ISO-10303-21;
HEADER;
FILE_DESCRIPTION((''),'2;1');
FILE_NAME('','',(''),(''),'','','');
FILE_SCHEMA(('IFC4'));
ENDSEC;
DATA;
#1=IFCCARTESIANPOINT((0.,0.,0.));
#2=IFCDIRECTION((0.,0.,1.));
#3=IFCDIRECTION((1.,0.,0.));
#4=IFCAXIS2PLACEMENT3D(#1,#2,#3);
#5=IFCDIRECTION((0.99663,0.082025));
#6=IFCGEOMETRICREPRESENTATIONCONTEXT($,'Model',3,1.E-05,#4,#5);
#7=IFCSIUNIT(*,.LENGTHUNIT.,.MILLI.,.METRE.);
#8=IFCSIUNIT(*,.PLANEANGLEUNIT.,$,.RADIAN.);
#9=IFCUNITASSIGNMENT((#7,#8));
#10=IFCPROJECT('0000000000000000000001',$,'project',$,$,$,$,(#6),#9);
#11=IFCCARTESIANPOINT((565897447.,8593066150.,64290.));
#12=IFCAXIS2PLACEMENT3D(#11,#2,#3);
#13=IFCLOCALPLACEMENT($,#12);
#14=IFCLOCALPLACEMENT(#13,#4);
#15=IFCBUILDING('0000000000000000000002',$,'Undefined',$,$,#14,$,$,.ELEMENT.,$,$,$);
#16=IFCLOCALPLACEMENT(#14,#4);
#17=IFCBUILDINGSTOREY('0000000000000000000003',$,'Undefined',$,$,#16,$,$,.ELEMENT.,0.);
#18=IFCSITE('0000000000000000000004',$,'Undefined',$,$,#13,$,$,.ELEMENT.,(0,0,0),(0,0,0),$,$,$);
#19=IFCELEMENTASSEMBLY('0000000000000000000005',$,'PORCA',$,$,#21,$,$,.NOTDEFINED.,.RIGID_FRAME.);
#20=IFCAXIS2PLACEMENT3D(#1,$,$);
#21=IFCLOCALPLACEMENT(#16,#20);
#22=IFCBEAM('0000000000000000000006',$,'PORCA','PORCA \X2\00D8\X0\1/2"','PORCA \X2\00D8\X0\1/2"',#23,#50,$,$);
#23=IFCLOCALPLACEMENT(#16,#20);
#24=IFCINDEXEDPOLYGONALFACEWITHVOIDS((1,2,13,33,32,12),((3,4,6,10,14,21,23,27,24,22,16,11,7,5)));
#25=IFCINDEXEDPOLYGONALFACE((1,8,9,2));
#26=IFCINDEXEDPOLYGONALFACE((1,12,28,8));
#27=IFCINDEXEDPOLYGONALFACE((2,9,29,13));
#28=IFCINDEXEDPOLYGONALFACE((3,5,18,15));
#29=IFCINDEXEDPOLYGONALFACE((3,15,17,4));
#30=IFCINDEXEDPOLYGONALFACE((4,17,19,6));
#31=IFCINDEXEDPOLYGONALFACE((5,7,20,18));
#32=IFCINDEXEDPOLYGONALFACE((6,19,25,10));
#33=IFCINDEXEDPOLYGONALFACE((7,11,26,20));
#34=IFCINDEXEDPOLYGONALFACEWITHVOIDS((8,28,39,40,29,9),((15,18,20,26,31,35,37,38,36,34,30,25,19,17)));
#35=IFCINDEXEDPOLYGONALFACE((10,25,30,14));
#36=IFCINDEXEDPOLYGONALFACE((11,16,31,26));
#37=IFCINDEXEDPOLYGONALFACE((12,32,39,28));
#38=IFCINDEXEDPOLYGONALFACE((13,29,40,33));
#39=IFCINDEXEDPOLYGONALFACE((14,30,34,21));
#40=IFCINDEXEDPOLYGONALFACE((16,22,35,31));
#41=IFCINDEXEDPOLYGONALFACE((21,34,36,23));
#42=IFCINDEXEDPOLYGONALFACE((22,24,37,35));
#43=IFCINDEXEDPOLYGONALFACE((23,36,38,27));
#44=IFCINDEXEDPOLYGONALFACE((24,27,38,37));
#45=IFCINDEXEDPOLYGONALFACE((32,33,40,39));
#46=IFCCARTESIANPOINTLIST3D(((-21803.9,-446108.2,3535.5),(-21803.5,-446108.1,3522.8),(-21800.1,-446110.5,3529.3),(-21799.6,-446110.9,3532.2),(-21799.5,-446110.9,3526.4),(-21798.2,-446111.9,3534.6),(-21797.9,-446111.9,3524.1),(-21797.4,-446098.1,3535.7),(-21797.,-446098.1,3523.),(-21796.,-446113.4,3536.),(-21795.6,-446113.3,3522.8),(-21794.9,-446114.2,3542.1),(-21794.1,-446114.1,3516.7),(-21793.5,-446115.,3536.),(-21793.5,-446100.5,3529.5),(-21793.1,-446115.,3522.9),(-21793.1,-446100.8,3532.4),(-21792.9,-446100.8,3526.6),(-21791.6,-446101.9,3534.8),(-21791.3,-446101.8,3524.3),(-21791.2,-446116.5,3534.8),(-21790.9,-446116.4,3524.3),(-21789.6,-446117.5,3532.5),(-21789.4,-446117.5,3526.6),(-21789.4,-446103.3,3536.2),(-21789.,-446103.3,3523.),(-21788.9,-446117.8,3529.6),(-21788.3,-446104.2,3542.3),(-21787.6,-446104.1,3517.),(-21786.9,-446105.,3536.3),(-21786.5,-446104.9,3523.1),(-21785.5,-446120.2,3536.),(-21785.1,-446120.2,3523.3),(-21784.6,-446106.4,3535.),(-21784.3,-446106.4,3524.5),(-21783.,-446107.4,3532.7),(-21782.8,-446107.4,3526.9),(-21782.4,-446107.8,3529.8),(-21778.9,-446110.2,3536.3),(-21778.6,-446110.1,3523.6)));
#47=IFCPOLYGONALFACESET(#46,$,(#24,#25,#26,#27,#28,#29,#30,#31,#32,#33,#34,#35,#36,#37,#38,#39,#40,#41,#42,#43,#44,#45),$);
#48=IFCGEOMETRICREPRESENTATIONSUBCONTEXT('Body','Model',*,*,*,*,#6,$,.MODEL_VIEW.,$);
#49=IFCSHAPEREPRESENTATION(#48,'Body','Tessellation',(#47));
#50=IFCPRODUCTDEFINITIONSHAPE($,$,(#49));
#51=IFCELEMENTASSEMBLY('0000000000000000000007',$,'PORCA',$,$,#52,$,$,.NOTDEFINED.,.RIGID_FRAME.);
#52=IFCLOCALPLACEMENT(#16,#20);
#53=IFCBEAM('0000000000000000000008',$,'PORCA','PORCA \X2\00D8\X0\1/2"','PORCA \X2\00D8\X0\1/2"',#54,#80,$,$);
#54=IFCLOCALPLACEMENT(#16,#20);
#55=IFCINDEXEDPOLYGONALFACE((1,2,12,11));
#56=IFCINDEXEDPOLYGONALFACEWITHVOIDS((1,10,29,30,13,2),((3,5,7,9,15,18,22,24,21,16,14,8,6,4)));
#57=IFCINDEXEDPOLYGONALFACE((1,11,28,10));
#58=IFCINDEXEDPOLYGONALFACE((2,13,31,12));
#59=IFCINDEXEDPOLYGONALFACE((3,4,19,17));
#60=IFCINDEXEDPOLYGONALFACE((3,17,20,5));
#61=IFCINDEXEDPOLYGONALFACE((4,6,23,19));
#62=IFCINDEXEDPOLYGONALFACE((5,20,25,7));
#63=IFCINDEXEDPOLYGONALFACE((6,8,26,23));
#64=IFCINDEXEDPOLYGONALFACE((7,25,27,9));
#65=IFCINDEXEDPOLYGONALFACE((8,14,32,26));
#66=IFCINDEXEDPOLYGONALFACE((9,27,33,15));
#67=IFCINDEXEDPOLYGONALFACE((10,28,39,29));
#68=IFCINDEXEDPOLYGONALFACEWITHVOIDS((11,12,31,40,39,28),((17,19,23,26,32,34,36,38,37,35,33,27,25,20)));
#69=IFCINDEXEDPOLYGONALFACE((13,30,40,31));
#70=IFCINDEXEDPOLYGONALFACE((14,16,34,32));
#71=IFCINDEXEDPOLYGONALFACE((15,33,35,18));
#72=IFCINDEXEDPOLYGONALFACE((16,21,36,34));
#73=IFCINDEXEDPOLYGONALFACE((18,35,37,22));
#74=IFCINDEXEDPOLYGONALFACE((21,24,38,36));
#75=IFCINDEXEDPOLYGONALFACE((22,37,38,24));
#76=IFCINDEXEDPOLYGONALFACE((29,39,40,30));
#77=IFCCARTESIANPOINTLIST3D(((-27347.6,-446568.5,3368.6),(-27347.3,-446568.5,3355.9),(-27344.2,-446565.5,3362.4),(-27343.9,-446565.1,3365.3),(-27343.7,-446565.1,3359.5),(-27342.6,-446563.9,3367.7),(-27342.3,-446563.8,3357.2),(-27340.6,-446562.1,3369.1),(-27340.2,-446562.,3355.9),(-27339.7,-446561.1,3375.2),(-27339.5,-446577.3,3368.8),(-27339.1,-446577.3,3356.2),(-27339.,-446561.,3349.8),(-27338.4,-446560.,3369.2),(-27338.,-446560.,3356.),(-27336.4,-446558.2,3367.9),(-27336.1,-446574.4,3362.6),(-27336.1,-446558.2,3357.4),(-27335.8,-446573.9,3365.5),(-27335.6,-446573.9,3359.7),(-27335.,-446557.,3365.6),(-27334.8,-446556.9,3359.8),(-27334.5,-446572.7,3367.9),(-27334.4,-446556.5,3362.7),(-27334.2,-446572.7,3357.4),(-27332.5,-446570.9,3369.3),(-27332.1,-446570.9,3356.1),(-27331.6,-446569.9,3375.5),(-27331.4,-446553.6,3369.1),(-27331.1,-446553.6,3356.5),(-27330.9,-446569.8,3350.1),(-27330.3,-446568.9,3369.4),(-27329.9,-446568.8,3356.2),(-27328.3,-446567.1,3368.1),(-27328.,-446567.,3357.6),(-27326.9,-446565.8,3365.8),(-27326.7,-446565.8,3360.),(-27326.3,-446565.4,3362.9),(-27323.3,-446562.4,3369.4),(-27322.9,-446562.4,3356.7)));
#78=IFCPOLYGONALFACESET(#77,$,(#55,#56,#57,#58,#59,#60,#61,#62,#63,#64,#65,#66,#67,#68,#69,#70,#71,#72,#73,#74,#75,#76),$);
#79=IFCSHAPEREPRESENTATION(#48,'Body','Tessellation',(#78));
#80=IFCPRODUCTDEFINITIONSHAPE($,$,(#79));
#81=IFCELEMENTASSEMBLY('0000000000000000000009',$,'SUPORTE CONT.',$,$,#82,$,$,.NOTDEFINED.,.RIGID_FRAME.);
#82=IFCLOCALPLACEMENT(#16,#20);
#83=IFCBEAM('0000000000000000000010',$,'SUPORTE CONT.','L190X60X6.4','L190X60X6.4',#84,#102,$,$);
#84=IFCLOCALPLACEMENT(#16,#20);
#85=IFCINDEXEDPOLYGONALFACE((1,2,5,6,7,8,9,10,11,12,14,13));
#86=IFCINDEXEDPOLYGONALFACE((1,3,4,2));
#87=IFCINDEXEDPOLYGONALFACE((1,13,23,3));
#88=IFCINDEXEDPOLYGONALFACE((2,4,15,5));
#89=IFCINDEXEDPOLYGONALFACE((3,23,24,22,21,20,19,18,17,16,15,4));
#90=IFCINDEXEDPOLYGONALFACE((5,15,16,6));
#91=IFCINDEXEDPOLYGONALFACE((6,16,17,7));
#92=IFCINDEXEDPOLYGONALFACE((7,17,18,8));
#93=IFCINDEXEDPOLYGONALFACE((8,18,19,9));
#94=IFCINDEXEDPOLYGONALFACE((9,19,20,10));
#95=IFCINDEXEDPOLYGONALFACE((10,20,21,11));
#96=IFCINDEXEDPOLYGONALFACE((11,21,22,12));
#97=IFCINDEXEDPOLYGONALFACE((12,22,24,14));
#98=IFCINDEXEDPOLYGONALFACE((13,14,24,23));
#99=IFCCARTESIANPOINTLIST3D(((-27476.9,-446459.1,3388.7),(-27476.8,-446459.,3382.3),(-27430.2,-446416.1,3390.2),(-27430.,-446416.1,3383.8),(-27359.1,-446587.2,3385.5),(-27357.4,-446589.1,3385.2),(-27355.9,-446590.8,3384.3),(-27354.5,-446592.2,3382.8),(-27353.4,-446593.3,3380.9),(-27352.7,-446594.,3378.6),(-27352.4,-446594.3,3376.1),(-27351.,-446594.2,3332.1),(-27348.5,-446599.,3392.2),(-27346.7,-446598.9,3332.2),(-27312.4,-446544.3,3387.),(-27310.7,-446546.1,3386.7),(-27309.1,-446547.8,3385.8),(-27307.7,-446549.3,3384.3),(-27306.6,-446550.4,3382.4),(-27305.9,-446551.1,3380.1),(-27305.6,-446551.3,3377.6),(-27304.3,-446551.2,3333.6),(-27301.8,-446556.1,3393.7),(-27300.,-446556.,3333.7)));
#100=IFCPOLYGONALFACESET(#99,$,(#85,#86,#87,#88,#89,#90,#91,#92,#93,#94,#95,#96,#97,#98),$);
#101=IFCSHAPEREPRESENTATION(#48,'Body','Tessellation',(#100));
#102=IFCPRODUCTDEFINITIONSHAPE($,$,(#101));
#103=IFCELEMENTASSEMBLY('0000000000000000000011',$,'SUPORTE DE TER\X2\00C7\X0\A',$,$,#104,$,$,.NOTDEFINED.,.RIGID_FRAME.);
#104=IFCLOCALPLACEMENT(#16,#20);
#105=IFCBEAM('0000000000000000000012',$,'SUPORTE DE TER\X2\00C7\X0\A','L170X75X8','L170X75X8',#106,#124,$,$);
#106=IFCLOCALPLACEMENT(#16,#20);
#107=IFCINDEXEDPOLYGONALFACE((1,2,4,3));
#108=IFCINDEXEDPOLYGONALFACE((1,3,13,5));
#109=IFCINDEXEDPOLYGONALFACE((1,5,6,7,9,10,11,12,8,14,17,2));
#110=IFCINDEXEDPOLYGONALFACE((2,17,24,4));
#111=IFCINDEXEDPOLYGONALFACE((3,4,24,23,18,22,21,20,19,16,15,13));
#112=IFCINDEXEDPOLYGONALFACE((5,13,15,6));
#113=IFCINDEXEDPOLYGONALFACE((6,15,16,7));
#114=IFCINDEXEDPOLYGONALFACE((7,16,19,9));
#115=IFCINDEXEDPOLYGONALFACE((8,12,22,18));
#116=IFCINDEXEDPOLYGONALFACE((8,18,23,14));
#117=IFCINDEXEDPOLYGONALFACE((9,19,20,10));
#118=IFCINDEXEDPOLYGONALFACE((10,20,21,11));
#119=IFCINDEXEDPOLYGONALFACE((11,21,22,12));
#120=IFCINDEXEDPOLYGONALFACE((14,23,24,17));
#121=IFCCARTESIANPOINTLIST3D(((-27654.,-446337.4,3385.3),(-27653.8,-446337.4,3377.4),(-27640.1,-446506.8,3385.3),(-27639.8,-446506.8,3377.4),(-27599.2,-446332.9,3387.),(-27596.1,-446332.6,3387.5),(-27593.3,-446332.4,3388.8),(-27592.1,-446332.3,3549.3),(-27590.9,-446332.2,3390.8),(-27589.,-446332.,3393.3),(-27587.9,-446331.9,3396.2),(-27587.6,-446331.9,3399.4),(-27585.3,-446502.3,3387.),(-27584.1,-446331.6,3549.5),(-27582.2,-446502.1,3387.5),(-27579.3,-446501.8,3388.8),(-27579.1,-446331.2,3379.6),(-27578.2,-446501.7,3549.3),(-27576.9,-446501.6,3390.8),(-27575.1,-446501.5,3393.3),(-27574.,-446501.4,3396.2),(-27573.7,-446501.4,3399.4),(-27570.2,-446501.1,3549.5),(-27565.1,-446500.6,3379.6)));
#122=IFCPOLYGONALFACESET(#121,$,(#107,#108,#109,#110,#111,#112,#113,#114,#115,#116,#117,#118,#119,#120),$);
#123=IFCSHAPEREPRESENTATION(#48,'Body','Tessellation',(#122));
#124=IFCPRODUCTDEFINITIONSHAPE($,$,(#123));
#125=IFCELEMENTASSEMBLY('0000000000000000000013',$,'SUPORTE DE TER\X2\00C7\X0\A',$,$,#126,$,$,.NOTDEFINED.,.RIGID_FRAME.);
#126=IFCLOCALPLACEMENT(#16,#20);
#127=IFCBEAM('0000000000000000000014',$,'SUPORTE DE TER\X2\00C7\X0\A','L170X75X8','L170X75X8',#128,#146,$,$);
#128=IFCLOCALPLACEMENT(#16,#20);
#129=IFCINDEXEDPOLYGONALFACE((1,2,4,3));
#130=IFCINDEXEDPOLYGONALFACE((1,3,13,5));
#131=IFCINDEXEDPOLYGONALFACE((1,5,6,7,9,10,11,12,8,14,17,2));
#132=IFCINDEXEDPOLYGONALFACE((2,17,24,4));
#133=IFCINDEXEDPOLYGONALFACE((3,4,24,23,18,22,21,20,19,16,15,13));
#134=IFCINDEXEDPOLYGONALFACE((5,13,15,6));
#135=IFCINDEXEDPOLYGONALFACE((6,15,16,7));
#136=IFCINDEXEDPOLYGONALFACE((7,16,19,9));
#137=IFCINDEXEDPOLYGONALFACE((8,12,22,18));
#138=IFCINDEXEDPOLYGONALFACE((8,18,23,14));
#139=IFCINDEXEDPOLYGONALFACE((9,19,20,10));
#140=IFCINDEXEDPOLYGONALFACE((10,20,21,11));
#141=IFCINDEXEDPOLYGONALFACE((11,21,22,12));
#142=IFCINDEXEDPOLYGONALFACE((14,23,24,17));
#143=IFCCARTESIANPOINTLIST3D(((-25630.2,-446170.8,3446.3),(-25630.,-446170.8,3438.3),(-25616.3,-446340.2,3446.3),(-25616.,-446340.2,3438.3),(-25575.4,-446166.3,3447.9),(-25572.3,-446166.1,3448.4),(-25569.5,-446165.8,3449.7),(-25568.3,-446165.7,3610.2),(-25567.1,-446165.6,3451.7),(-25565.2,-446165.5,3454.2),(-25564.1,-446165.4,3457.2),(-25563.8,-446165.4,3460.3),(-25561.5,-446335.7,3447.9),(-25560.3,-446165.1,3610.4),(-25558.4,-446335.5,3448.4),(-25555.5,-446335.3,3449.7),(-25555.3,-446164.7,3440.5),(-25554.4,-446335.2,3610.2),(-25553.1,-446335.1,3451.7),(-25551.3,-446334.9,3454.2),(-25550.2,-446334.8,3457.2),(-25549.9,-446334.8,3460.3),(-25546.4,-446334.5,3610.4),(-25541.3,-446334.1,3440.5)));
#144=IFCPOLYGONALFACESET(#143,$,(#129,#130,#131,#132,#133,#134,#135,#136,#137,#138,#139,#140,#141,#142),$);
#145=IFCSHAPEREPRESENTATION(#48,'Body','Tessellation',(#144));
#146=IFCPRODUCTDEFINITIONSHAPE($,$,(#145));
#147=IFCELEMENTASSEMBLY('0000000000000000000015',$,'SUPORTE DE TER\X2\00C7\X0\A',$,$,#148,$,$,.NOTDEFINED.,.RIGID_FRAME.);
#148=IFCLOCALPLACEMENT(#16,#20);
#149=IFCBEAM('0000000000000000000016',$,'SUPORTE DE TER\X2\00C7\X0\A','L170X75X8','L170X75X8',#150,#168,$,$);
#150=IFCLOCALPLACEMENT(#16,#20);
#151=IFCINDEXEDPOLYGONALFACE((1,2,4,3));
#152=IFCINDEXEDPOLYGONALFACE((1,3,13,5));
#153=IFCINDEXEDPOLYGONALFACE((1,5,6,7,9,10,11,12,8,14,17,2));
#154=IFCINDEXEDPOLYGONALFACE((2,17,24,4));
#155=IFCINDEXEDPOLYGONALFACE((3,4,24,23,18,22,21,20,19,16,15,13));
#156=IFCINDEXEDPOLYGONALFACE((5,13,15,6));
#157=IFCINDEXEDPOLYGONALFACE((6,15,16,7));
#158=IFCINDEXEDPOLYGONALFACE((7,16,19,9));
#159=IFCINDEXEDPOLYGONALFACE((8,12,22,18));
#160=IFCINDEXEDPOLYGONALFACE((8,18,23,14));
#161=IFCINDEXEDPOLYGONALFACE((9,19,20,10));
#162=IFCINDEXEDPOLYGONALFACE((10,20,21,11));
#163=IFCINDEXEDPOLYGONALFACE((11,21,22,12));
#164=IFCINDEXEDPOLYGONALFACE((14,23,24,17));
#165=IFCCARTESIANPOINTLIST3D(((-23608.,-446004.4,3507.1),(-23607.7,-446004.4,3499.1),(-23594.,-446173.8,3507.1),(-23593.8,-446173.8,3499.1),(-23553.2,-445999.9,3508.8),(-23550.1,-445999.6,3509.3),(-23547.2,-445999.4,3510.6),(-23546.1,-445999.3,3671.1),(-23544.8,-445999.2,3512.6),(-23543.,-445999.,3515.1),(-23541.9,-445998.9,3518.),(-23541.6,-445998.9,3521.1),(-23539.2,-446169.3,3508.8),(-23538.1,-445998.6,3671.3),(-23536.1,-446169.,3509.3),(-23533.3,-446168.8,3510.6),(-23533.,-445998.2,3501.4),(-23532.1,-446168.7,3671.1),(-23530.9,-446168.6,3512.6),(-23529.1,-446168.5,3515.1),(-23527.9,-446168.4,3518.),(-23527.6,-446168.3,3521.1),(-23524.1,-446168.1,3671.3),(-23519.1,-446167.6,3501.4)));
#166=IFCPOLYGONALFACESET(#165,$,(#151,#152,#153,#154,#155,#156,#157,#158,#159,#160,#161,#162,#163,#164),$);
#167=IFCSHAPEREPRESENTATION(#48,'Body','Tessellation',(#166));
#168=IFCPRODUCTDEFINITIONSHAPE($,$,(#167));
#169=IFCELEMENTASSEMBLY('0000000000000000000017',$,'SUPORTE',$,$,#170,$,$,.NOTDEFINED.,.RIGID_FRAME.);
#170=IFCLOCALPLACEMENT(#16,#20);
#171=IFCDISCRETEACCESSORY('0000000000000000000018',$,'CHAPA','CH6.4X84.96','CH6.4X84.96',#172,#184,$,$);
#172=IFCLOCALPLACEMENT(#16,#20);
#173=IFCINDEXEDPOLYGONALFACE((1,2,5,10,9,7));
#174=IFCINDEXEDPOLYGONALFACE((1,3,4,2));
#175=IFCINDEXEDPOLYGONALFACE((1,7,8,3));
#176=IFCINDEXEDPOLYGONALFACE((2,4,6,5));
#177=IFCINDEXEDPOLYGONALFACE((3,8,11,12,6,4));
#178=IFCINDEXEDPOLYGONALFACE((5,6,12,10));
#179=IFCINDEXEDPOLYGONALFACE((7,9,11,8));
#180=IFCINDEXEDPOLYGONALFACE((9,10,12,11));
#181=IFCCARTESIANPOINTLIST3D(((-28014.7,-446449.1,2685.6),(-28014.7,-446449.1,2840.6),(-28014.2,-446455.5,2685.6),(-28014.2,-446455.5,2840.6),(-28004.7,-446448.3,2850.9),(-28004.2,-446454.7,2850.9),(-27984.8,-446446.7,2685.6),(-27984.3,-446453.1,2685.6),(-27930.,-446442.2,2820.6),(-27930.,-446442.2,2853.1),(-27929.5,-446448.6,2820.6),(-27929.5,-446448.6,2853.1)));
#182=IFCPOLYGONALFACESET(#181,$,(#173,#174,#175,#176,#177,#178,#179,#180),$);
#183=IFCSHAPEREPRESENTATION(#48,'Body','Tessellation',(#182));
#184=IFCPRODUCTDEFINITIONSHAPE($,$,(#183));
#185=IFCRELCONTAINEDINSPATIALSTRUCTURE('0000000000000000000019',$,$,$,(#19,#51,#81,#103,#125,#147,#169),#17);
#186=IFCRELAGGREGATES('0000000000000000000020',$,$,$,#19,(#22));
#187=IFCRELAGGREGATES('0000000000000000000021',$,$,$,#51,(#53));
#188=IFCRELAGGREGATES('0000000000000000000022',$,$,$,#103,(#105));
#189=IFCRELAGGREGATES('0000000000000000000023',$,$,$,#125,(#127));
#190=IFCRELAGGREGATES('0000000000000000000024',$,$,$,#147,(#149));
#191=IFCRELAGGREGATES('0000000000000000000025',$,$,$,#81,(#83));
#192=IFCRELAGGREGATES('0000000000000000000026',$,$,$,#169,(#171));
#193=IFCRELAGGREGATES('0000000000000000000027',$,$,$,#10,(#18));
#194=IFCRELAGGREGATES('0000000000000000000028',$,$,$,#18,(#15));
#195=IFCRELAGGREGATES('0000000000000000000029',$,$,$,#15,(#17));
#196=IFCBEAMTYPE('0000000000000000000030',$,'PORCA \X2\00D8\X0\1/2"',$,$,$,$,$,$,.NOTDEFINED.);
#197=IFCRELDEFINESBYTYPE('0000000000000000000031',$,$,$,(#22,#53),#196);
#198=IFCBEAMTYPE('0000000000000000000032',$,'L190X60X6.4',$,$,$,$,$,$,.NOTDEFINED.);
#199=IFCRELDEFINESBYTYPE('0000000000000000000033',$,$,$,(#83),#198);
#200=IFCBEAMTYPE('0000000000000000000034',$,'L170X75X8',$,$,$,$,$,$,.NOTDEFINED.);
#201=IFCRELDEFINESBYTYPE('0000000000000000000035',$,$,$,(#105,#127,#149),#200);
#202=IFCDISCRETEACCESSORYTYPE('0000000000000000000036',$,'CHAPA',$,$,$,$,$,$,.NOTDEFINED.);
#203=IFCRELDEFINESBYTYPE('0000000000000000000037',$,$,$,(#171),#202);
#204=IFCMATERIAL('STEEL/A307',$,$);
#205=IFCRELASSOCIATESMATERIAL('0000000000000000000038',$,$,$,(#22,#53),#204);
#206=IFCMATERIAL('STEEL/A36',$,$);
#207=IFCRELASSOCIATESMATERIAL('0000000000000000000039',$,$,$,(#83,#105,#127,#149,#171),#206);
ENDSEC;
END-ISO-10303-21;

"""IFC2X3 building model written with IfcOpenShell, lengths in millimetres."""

from ifc_helpers import new_model, si_unit, direction, frame, origin_with_axes, origin_2d_with_axis, place, context, subcontext, project, spatial, polyline, l_section, outline, extrude, material, type_object, element, aggregate, save


model = new_model("IFC2X3")

# Units and contexts
model_context = context("Model", 3, precision=1e-05, world=origin_with_axes(), true_north=direction((0.99663, 0.082025)))
body_context = subcontext(model_context, "Body", "Model", "MODEL_VIEW")
ifc_project = project(units=[si_unit("LENGTHUNIT", "METRE", prefix="MILLI"), si_unit("PLANEANGLEUNIT", "RADIAN")], contexts=[model_context])

# Site, building, storey
site_placement = place(None, frame((565897447.0, 8593066150.0, 64290.0), z_axis=(0.0, 0.0, 1.0), x_axis=(1.0, 0.0, 0.0)))
site = spatial("IfcSite", under=ifc_project, at=site_placement, Name="Undefined", CompositionType="ELEMENT", RefLatitude=(0, 0, 0), RefLongitude=(0, 0, 0))
building_placement = place(site_placement, origin_with_axes())
building = spatial("IfcBuilding", under=site, at=building_placement, Name="Undefined", CompositionType="ELEMENT")
storey_placement = place(building_placement, origin_with_axes())
storey = spatial("IfcBuildingStorey", under=building, at=storey_placement, Name="Undefined", CompositionType="ELEMENT", Elevation=0.0)

# Element assemblies, beams
ifc_material_1 = material(Name="STEEL/A307")
assembly_1_placement = place(storey_placement, origin_with_axes())
assembly_1 = element("IfcElementAssembly", 1, at=assembly_1_placement, inside=storey, Name="PORCA", AssemblyPlace="NOTDEFINED", PredefinedType="RIGID_FRAME")
beam_type_1 = type_object("IfcBeamType", Name="PORCA Ø1/2\"", PredefinedType="NOTDEFINED")
beam_1_placement = place(assembly_1_placement, frame((-21788.0, -446104.1, 3529.6), z_axis=(0.836984, -0.546715, 0.02368), x_axis=(-0.546411, -0.837315, -0.018398)))
beam_1 = element("IfcBeam", 2, at=beam_1_placement, type_object=beam_type_1, material=ifc_material_1, Name="PORCA", Description="PORCA Ø1/2\"", ObjectType="PORCA Ø1/2\"", context=body_context, shape_type="SweptSolid", body=[
    extrude(outline(polyline([(-6.3, -11.0), (-12.7, 0.0), (-6.3, 11.0), (6.3, 11.0), (12.7, 0.0), (6.3, -11.0), (-6.3, -11.0)]), holes=[polyline([(5.3, 4.2), (2.9, 6.0), (0.0, 6.7), (-2.9, 6.0), (-5.3, 4.2), (-6.6, 1.5), (-6.6, -1.5), (-5.3, -4.2), (-2.9, -6.0), (0.0, -6.7), (2.9, -6.0), (5.3, -4.2), (6.6, -1.5), (6.6, 1.5), (5.3, 4.2)])]), frame((12.0, 0.0, 0.0), z_axis=(-1.0, 0.0, 0.0), x_axis=(0.0, -1.0, 0.0)), (0.0, 0.0, 1.0), 12.0),
])
aggregate(assembly_1, [beam_1])
assembly_2_placement = place(storey_placement, origin_with_axes())
assembly_2 = element("IfcElementAssembly", 3, at=assembly_2_placement, inside=storey, Name="PORCA", AssemblyPlace="NOTDEFINED", PredefinedType="RIGID_FRAME")
beam_2_placement = place(assembly_2_placement, frame((-27339.3, -446561.0, 3362.5), z_axis=(0.736334, 0.676203, 0.02368), x_axis=(0.675958, -0.736711, 0.018398)))
beam_2 = element("IfcBeam", 4, at=beam_2_placement, type_object=beam_type_1, material=ifc_material_1, Name="PORCA", Description="PORCA Ø1/2\"", ObjectType="PORCA Ø1/2\"", context=body_context, shape_type="SweptSolid", body=[
    extrude(outline(polyline([(-6.3, -11.0), (-12.7, 0.0), (-6.3, 11.0), (6.3, 11.0), (12.7, 0.0), (6.3, -11.0), (-6.3, -11.0)]), holes=[polyline([(5.3, 4.2), (2.9, 6.0), (0.0, 6.7), (-2.9, 6.0), (-5.3, 4.2), (-6.6, 1.5), (-6.6, -1.5), (-5.3, -4.2), (-2.9, -6.0), (0.0, -6.7), (2.9, -6.0), (5.3, -4.2), (6.6, -1.5), (6.6, 1.5), (5.3, 4.2)])]), frame((12.0, 0.0, 0.0), z_axis=(-1.0, 0.0, 0.0), x_axis=(0.0, -1.0, 0.0)), (0.0, 0.0, 1.0), 12.0),
])
aggregate(assembly_2, [beam_2])
assembly_3_placement = place(storey_placement, origin_with_axes())
assembly_3 = element("IfcElementAssembly", 5, at=assembly_3_placement, inside=storey, Name="SUPORTE CONT.", AssemblyPlace="NOTDEFINED", PredefinedType="RIGID_FRAME")
ifc_material_2 = material(Name="STEEL/A36")
beam_type_2 = type_object("IfcBeamType", Name="L190X60X6.4", PredefinedType="NOTDEFINED")
beam_3_placement = place(assembly_3_placement, frame((-27365.1, -446486.0, 3362.0), z_axis=(-0.675958, 0.736711, -0.018398), x_axis=(-0.736334, -0.676203, -0.02368)))
beam_3 = element("IfcBeam", 6, at=beam_3_placement, type_object=beam_type_2, material=ifc_material_2, Name="SUPORTE CONT.", Description="L190X60X6.4", ObjectType="L190X60X6.4", context=body_context, shape_type="SweptSolid", body=[
    extrude(l_section(Depth=190.0, Width=60.0, Thickness=6.4, FilletRadius=9.6, at=origin_2d_with_axis()), frame((63.5, 0.0, 0.0), z_axis=(-1.0, 0.0, 0.0), x_axis=(0.0, -1.0, 0.0)), (0.0, 0.0, 1.0), 63.5),
])
assembly_4_placement = place(storey_placement, origin_with_axes())
assembly_4 = element("IfcElementAssembly", 7, at=assembly_4_placement, inside=storey, Name="SUPORTE DE TERÇA", AssemblyPlace="NOTDEFINED", PredefinedType="RIGID_FRAME")
beam_type_3 = type_object("IfcBeamType", Name="L170X75X8", PredefinedType="NOTDEFINED")
beam_4_placement = place(assembly_4_placement, frame((-27619.0, -446334.5, 3463.4), z_axis=(-0.029885, -0.00246, 0.99955), x_axis=(0.082025, -0.99663, 0.0)))
beam_4 = element("IfcBeam", 8, at=beam_4_placement, type_object=beam_type_3, material=ifc_material_2, Name="SUPORTE DE TERÇA", Description="L170X75X8", ObjectType="L170X75X8", context=body_context, shape_type="SweptSolid", body=[
    extrude(l_section(Depth=170.0, Width=75.0, Thickness=8.0, FilletRadius=12.0, at=origin_2d_with_axis()), frame((170.0, 0.0, 0.0), z_axis=(-1.0, 0.0, 0.0), x_axis=(0.0, -1.0, 0.0)), (0.0, 0.0, 1.0), 170.0),
])
aggregate(assembly_4, [beam_4])
assembly_5_placement = place(storey_placement, origin_with_axes())
assembly_5 = element("IfcElementAssembly", 9, at=assembly_5_placement, inside=storey, Name="SUPORTE DE TERÇA", AssemblyPlace="NOTDEFINED", PredefinedType="RIGID_FRAME")
beam_5_placement = place(assembly_5_placement, frame((-25595.2, -446167.9, 3524.4), z_axis=(-0.029885, -0.00246, 0.99955), x_axis=(0.082025, -0.99663, 0.0)))
beam_5 = element("IfcBeam", 10, at=beam_5_placement, type_object=beam_type_3, material=ifc_material_2, Name="SUPORTE DE TERÇA", Description="L170X75X8", ObjectType="L170X75X8", context=body_context, shape_type="SweptSolid", body=[
    extrude(l_section(Depth=170.0, Width=75.0, Thickness=8.0, FilletRadius=12.0, at=origin_2d_with_axis()), frame((170.0, 0.0, 0.0), z_axis=(-1.0, 0.0, 0.0), x_axis=(0.0, -1.0, 0.0)), (0.0, 0.0, 1.0), 170.0),
])
aggregate(assembly_5, [beam_5])
assembly_6_placement = place(storey_placement, origin_with_axes())
assembly_6 = element("IfcElementAssembly", 11, at=assembly_6_placement, inside=storey, Name="SUPORTE DE TERÇA", AssemblyPlace="NOTDEFINED", PredefinedType="RIGID_FRAME")
beam_6_placement = place(assembly_6_placement, frame((-23572.9, -446001.5, 3585.2), z_axis=(-0.029885, -0.00246, 0.99955), x_axis=(0.082025, -0.99663, 0.0)))
beam_6 = element("IfcBeam", 12, at=beam_6_placement, type_object=beam_type_3, material=ifc_material_2, Name="SUPORTE DE TERÇA", Description="L170X75X8", ObjectType="L170X75X8", context=body_context, shape_type="SweptSolid", body=[
    extrude(l_section(Depth=170.0, Width=75.0, Thickness=8.0, FilletRadius=12.0, at=origin_2d_with_axis()), frame((170.0, 0.0, 0.0), z_axis=(-1.0, 0.0, 0.0), x_axis=(0.0, -1.0, 0.0)), (0.0, 0.0, 1.0), 170.0),
])
aggregate(assembly_6, [beam_6])

# Shared definitions
discrete_accessory_type_1 = type_object("IfcDiscreteAccessoryType", Name="CHAPA")
aggregate(assembly_3, [beam_3])

# Element assembly, discrete accessory
assembly_7_placement = place(storey_placement, origin_with_axes())
assembly_7 = element("IfcElementAssembly", 13, at=assembly_7_placement, inside=storey, Name="SUPORTE", AssemblyPlace="NOTDEFINED", PredefinedType="RIGID_FRAME")
discrete_accessory_1_placement = place(assembly_7_placement, frame((-28014.4, -446452.3, 2850.6), z_axis=(0.082025, -0.99663, 0.0), x_axis=(0.0, 0.0, -1.0)))
discrete_accessory_1 = element("IfcDiscreteAccessory", 14, at=discrete_accessory_1_placement, type_object=discrete_accessory_type_1, material=ifc_material_2, Name="CHAPA", Description="CH6.4X84.96", ObjectType="CH6.4X84.96", context=body_context, shape_type="SweptSolid", body=[
    extrude(outline(polyline([(-0.3, 10.0), (10.0, 0.0), (165.0, 0.0), (165.0, 30.0), (30.0, 85.0), (-2.5, 85.0), (-0.3, 10.0)])), frame((0.0, 0.0, -3.2), z_axis=(0.0, 0.0, 1.0), x_axis=(1.0, 0.0, 0.0)), (0.0, 0.0, 1.0), 6.4),
])
aggregate(assembly_7, [discrete_accessory_1])

save(model, "model.ifc")
